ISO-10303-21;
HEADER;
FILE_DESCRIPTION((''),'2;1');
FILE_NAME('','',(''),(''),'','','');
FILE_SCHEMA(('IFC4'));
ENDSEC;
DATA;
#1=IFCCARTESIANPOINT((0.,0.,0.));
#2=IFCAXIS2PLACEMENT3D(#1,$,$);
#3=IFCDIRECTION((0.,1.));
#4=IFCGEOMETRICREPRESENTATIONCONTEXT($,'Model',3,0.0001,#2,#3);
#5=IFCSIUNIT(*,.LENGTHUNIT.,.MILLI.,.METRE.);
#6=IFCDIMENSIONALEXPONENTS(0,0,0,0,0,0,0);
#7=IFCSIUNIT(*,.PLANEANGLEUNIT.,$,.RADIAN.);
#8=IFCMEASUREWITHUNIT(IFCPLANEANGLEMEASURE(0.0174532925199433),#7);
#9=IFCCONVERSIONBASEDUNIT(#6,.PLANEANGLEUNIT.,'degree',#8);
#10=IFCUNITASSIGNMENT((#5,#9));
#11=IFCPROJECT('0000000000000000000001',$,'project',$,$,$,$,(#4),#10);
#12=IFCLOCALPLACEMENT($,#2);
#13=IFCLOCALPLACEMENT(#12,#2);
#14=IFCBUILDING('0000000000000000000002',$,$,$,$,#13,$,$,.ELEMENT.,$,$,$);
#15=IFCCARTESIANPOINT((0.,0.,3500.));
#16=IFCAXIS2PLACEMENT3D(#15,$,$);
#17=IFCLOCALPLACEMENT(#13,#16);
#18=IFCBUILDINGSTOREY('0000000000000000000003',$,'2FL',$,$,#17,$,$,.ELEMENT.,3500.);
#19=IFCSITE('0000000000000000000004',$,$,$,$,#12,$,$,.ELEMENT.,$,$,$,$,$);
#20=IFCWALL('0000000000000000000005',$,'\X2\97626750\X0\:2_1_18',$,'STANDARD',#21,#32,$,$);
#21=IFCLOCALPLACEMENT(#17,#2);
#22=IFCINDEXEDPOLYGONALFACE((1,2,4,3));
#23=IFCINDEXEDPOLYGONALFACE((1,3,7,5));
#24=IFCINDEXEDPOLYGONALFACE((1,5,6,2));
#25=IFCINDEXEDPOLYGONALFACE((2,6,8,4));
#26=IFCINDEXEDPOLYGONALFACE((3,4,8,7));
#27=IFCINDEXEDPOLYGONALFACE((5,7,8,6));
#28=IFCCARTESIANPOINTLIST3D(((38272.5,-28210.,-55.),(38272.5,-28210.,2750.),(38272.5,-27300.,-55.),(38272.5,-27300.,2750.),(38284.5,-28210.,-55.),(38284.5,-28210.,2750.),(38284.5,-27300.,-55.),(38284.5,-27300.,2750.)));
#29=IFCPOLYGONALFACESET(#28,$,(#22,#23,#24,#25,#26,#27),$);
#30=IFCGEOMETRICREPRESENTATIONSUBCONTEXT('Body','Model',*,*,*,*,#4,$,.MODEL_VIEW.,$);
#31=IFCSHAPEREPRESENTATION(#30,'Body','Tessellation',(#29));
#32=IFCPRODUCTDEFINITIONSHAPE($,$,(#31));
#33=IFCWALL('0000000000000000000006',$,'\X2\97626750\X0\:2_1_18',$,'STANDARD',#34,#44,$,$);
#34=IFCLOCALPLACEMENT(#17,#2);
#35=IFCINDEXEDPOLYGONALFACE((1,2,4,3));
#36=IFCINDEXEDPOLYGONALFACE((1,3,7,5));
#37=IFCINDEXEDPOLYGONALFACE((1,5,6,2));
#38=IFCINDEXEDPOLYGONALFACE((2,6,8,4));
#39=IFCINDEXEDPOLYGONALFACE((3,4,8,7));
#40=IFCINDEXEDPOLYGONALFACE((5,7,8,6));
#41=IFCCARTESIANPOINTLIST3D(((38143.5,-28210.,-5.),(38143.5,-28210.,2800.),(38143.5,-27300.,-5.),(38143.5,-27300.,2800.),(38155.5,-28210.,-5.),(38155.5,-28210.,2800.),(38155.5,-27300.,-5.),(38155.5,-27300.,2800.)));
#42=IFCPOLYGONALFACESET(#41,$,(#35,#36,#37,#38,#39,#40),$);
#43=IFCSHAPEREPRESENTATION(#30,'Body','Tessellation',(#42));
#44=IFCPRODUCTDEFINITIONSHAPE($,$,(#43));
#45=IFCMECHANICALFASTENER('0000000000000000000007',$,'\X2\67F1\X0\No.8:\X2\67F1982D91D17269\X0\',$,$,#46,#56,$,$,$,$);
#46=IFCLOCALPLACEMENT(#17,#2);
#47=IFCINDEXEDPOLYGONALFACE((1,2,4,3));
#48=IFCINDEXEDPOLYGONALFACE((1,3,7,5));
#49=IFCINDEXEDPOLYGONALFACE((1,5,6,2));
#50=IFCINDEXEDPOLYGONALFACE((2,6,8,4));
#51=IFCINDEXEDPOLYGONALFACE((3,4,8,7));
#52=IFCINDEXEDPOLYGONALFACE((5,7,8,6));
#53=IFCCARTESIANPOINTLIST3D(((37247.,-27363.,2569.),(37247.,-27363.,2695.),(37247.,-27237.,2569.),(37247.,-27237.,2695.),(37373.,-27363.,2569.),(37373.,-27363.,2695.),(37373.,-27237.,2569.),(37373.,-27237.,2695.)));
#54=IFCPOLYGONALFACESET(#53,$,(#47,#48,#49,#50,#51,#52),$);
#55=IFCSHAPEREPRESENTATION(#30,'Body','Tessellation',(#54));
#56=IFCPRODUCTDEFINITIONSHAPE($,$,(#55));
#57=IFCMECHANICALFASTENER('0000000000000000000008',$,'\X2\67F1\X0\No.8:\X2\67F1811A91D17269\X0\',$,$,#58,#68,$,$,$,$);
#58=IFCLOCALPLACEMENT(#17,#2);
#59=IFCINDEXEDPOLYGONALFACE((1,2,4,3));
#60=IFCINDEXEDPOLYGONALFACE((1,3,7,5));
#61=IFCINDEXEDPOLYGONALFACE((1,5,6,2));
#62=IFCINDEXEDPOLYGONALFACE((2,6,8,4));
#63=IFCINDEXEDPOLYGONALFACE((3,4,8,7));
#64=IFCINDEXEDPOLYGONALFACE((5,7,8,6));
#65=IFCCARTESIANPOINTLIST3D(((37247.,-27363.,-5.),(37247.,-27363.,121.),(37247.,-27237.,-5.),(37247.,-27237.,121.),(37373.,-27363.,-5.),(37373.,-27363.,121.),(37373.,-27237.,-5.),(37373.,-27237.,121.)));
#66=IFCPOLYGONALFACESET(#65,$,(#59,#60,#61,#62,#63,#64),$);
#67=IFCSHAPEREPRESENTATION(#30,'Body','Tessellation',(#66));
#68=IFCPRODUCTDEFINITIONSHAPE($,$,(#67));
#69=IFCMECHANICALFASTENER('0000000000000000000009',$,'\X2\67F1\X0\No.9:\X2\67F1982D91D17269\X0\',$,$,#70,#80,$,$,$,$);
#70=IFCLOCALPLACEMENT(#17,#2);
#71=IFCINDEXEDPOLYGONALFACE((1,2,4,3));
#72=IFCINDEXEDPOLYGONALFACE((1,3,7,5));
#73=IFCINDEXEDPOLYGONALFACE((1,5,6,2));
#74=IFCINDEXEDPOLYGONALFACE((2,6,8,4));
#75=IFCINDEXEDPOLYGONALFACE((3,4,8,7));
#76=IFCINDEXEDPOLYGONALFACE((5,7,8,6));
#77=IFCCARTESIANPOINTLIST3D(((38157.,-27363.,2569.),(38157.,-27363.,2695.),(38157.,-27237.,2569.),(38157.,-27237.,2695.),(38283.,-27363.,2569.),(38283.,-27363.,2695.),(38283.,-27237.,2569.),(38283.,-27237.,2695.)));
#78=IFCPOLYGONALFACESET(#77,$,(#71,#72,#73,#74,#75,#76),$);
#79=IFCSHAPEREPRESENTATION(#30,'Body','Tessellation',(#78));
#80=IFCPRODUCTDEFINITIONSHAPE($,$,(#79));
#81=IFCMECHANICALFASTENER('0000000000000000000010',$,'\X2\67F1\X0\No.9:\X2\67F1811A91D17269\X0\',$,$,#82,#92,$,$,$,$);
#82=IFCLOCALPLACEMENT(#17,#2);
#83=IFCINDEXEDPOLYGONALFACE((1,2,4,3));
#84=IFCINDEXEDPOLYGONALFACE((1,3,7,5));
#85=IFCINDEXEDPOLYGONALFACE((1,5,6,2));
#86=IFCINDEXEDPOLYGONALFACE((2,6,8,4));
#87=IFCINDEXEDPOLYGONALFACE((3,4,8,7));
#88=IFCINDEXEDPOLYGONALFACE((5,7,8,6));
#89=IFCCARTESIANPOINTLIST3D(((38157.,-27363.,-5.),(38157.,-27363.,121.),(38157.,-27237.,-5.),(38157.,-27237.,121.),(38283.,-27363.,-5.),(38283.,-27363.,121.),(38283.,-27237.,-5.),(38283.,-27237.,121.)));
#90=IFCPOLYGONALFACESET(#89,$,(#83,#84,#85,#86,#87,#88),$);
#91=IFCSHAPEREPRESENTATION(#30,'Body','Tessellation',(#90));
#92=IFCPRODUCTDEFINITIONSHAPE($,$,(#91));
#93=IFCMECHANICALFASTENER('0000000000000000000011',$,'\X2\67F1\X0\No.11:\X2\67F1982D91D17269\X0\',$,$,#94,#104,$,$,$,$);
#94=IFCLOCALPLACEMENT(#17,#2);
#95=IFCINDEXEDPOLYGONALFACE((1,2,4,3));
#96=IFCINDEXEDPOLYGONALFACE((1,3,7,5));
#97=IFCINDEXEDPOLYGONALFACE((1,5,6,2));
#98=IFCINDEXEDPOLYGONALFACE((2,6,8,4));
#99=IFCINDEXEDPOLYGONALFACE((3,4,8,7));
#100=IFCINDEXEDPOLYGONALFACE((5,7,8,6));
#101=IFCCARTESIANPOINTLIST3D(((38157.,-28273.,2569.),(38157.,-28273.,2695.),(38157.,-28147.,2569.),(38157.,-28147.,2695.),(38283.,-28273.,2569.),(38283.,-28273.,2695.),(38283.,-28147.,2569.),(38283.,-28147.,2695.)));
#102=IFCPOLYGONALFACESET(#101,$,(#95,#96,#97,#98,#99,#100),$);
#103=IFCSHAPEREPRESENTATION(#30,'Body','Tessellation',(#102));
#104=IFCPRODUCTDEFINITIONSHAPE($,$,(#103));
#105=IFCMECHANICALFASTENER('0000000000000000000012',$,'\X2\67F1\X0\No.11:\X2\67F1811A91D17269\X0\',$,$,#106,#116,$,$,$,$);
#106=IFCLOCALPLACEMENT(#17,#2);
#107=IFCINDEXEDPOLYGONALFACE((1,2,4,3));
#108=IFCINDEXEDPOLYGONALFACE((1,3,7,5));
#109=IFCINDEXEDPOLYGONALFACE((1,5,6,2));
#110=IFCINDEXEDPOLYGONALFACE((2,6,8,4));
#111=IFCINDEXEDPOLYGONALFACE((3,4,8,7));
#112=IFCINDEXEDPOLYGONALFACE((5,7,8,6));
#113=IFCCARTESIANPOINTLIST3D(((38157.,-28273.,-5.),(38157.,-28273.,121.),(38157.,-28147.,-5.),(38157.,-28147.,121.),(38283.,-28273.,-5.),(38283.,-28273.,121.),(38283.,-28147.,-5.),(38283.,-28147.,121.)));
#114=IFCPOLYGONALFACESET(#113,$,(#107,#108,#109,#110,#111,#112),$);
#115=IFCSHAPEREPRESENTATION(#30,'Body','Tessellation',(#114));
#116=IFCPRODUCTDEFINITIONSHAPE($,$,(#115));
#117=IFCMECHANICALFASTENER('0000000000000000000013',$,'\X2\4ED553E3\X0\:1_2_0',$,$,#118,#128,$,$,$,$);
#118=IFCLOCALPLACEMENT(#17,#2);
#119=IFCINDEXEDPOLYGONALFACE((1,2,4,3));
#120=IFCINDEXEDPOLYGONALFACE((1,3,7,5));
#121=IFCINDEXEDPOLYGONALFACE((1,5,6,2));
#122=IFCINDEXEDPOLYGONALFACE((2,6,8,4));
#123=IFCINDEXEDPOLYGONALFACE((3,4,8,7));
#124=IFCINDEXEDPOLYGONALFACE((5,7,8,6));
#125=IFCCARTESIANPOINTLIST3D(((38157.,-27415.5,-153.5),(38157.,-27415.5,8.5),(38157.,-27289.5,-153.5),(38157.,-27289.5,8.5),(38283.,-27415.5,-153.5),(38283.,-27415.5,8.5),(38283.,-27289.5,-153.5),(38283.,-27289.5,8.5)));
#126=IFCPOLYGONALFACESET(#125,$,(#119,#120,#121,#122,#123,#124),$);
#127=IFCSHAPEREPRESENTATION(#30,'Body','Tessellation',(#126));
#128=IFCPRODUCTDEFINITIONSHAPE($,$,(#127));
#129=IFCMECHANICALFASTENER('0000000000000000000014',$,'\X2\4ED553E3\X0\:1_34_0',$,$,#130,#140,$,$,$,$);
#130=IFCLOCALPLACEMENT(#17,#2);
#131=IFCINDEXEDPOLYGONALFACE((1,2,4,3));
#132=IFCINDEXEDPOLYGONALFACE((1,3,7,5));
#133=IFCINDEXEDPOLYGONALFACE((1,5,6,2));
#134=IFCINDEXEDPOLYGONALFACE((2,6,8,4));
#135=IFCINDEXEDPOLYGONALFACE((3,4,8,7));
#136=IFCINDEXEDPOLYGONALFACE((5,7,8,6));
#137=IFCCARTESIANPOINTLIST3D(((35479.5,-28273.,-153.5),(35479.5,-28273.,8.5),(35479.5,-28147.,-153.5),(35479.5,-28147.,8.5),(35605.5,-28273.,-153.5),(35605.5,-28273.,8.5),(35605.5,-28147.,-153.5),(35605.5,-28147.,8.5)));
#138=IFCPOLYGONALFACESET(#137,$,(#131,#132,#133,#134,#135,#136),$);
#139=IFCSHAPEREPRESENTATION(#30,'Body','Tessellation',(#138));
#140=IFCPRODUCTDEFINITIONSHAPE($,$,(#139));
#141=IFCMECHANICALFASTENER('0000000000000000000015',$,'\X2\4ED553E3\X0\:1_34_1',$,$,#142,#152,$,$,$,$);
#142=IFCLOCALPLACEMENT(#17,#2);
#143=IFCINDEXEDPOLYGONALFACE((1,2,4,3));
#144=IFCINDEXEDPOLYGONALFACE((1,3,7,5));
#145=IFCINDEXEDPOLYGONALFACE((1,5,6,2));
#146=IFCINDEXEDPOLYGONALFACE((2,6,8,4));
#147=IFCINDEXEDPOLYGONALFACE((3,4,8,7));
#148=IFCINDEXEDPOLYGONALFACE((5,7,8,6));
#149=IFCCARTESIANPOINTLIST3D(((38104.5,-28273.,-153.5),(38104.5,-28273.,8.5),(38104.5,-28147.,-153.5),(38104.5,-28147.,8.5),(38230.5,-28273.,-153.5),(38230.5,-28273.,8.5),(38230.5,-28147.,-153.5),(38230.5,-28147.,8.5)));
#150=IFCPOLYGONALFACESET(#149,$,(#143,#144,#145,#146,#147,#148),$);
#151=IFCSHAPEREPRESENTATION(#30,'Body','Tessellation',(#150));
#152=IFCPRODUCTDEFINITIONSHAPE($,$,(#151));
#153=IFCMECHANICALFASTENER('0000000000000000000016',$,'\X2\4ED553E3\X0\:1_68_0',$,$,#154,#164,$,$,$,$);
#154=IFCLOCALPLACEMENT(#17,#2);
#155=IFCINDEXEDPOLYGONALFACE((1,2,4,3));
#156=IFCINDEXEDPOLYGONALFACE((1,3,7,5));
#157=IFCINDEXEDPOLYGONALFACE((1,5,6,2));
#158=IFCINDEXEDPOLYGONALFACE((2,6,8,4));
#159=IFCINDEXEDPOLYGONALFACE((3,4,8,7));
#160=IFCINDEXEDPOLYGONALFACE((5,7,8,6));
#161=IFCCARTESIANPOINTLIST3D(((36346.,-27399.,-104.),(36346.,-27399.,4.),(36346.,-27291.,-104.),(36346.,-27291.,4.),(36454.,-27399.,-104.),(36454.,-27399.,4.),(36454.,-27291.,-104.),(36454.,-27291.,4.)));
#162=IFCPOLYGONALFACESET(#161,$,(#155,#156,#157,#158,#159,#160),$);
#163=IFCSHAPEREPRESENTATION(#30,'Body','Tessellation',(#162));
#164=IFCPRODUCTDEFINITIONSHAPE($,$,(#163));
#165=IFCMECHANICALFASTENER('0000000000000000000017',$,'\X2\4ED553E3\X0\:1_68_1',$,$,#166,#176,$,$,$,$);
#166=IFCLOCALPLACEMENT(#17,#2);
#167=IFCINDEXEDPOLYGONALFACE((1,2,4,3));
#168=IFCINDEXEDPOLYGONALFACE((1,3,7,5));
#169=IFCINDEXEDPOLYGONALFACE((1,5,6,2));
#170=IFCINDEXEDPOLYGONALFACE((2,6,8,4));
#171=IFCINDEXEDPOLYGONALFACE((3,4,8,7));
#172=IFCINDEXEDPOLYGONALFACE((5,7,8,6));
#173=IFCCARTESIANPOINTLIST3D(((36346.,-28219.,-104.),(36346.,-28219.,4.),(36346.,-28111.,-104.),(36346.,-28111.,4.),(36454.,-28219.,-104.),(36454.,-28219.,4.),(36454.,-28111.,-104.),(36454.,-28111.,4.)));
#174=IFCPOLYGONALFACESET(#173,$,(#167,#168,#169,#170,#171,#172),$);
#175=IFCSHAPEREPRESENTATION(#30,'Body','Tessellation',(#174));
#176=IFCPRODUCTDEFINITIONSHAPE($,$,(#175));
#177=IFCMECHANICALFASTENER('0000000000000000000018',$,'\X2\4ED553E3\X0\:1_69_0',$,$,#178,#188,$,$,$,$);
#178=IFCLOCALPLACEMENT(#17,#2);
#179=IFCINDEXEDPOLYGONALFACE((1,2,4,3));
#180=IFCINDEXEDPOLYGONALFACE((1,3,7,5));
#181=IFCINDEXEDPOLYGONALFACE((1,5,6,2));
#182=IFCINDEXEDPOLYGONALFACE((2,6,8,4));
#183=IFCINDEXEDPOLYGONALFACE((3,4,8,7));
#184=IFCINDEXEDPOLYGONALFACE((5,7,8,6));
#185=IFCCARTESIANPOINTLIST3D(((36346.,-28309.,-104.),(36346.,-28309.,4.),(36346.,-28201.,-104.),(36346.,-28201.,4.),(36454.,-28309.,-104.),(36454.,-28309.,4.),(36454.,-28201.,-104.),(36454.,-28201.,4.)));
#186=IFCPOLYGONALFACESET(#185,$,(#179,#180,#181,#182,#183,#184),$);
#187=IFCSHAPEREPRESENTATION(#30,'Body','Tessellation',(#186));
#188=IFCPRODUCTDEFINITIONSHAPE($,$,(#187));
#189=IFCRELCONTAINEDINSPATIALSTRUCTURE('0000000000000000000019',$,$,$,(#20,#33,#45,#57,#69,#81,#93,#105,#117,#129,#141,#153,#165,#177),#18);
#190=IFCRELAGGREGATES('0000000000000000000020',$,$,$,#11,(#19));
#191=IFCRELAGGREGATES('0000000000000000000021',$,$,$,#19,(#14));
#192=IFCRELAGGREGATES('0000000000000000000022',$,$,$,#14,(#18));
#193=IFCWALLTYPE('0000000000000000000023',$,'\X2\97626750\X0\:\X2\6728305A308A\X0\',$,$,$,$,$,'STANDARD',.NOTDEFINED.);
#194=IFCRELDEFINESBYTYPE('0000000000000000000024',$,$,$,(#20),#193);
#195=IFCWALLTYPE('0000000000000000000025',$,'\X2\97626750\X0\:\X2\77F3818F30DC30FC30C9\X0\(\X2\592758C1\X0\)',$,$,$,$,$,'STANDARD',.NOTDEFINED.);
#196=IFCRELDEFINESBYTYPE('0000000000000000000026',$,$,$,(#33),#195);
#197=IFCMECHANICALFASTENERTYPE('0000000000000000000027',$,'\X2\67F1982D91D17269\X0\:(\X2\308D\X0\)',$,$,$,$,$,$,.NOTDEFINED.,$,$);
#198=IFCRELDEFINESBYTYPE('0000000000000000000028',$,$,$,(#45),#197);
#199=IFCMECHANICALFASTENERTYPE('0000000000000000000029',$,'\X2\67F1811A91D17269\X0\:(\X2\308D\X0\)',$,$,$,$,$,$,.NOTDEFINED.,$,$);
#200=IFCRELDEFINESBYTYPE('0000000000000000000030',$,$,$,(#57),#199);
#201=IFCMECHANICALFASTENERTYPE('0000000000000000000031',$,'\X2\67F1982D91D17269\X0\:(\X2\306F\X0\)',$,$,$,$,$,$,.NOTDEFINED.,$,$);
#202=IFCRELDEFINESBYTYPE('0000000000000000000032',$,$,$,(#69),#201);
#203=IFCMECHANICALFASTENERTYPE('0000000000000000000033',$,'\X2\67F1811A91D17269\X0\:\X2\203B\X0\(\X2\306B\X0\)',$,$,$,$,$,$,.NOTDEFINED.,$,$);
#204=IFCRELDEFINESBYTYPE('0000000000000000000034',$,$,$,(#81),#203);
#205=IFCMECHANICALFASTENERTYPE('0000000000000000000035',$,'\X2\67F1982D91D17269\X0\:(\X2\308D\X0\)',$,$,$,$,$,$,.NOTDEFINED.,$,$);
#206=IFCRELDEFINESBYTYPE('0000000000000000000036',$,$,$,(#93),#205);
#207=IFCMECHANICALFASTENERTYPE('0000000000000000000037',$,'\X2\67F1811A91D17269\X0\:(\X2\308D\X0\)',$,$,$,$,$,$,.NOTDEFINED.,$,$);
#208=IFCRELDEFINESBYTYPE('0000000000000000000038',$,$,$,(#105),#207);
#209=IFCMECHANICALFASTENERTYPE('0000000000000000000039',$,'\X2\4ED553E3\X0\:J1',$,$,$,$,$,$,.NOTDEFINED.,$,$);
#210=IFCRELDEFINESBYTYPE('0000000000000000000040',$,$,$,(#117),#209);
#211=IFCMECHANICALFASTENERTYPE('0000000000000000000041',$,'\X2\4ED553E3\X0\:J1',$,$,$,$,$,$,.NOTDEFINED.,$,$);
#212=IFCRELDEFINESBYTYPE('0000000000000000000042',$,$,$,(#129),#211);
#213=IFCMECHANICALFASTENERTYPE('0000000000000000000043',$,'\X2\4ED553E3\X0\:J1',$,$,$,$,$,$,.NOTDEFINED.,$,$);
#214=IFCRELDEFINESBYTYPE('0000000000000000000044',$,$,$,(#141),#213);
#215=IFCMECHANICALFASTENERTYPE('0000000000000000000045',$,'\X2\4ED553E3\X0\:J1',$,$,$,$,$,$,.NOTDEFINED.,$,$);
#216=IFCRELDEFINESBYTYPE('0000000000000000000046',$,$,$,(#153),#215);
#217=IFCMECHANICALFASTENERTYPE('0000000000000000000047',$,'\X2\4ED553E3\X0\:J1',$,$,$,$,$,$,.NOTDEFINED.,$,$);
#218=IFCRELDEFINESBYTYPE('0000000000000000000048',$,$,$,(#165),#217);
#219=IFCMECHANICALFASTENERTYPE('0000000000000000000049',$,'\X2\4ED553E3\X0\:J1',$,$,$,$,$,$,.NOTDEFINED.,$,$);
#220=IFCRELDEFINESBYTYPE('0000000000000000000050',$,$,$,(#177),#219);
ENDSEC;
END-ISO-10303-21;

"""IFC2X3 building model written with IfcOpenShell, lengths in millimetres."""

from ifc_helpers import new_model, entity, si_unit, converted_unit, direction, frame, origin, origin_with_axes, origin_2d, place, context, subcontext, project, spatial, polyline, rectangle, outline, extrude, type_object, element, save


model = new_model("IFC2X3")

# Units and contexts
model_context = context("Model", 3, precision=0.0001, world=origin(), true_north=direction((0.0, 1.0)))
body_context = subcontext(model_context, "Body", "Model", "MODEL_VIEW")
ifc_project = project(units=[si_unit("LENGTHUNIT", "METRE", prefix="MILLI"), converted_unit("PLANEANGLEUNIT", "degree", entity("IfcPlaneAngleMeasure", 0.0174532925199433), si_unit("PLANEANGLEUNIT", "RADIAN"), dimensions=[0, 0, 0, 0, 0, 0, 0])], contexts=[model_context])

# Site, building, storey
site_placement = place(None, origin())
site = spatial("IfcSite", under=ifc_project, at=site_placement, CompositionType="ELEMENT")
building_placement = place(site_placement, origin())
building = spatial("IfcBuilding", under=site, at=building_placement, CompositionType="ELEMENT")
storey_placement = place(building_placement, frame((0.0, 0.0, 3500.0)))
storey = spatial("IfcBuildingStorey", under=building, at=storey_placement, Name="2FL", CompositionType="ELEMENT", Elevation=3500.0)

# Walls
wall_type_1 = type_object("IfcWallType", Name="面材:木ずり", ElementType="STANDARD", PredefinedType="NOTDEFINED")
wall_1_placement = place(storey_placement, frame((38284.5, -27755.0, -55.0), z_axis=(-1.0, 0.0, 0.0), x_axis=(0.0, -1.0, 0.0)))
element("IfcWall", 1, at=wall_1_placement, inside=storey, type_object=wall_type_1, Name="面材:2_1_18", ObjectType="STANDARD", context=body_context, shape_type="SweptSolid", body=[
    extrude(outline(polyline([(455.0, 0.0, 0.0), (-455.0, 0.0, 0.0), (-455.0, 2805.0, 0.0), (455.0, 2805.0, 0.0), (455.0, 0.0, 0.0)])), origin_with_axes(), (0.0, 0.0, 1.0), 12.0),
])
wall_type_2 = type_object("IfcWallType", Name="面材:石膏ボード(大壁)", ElementType="STANDARD", PredefinedType="NOTDEFINED")
wall_2_placement = place(storey_placement, frame((38155.5, -27755.0, -5.0), z_axis=(-1.0, 0.0, 0.0), x_axis=(0.0, -1.0, 0.0)))
element("IfcWall", 2, at=wall_2_placement, inside=storey, type_object=wall_type_2, Name="面材:2_1_18", ObjectType="STANDARD", context=body_context, shape_type="SweptSolid", body=[
    extrude(outline(polyline([(455.0, 0.0, 0.0), (-455.0, 0.0, 0.0), (-455.0, 2805.0, 0.0), (455.0, 2805.0, 0.0), (455.0, 0.0, 0.0)])), origin_with_axes(), (0.0, 0.0, 1.0), 12.0),
])

# Mechanical fasteners
mechanical_fastener_type_1 = type_object("IfcMechanicalFastenerType", Name="柱頭金物:(ろ)")
mechanical_fastener_1_placement = place(storey_placement, frame((37310.0, -27300.0, 2569.0)))
element("IfcMechanicalFastener", 3, at=mechanical_fastener_1_placement, inside=storey, type_object=mechanical_fastener_type_1, Name="柱No.8:柱頭金物", context=body_context, shape_type="SweptSolid", body=[
    extrude(rectangle(XDim=126.0, YDim=126.0, at=origin_2d()), origin_with_axes(), (0.0, 0.0, 1.0), 126.0),
])
mechanical_fastener_type_2 = type_object("IfcMechanicalFastenerType", Name="柱脚金物:(ろ)")
mechanical_fastener_2_placement = place(storey_placement, frame((37310.0, -27300.0, -5.0)))
element("IfcMechanicalFastener", 4, at=mechanical_fastener_2_placement, inside=storey, type_object=mechanical_fastener_type_2, Name="柱No.8:柱脚金物", context=body_context, shape_type="SweptSolid", body=[
    extrude(rectangle(XDim=126.0, YDim=126.0, at=origin_2d()), origin_with_axes(), (0.0, 0.0, 1.0), 126.0),
])
mechanical_fastener_type_3 = type_object("IfcMechanicalFastenerType", Name="柱頭金物:(は)")
mechanical_fastener_3_placement = place(storey_placement, frame((38220.0, -27300.0, 2569.0)))
element("IfcMechanicalFastener", 5, at=mechanical_fastener_3_placement, inside=storey, type_object=mechanical_fastener_type_3, Name="柱No.9:柱頭金物", context=body_context, shape_type="SweptSolid", body=[
    extrude(rectangle(XDim=126.0, YDim=126.0, at=origin_2d()), origin_with_axes(), (0.0, 0.0, 1.0), 126.0),
])
mechanical_fastener_type_4 = type_object("IfcMechanicalFastenerType", Name="柱脚金物:※(に)")
mechanical_fastener_4_placement = place(storey_placement, frame((38220.0, -27300.0, -5.0)))
element("IfcMechanicalFastener", 6, at=mechanical_fastener_4_placement, inside=storey, type_object=mechanical_fastener_type_4, Name="柱No.9:柱脚金物", context=body_context, shape_type="SweptSolid", body=[
    extrude(rectangle(XDim=126.0, YDim=126.0, at=origin_2d()), origin_with_axes(), (0.0, 0.0, 1.0), 126.0),
])
mechanical_fastener_type_5 = type_object("IfcMechanicalFastenerType", Name="柱頭金物:(ろ)")
mechanical_fastener_5_placement = place(storey_placement, frame((38220.0, -28210.0, 2569.0)))
element("IfcMechanicalFastener", 7, at=mechanical_fastener_5_placement, inside=storey, type_object=mechanical_fastener_type_5, Name="柱No.11:柱頭金物", context=body_context, shape_type="SweptSolid", body=[
    extrude(rectangle(XDim=126.0, YDim=126.0, at=origin_2d()), origin_with_axes(), (0.0, 0.0, 1.0), 126.0),
])
mechanical_fastener_type_6 = type_object("IfcMechanicalFastenerType", Name="柱脚金物:(ろ)")
mechanical_fastener_6_placement = place(storey_placement, frame((38220.0, -28210.0, -5.0)))
element("IfcMechanicalFastener", 8, at=mechanical_fastener_6_placement, inside=storey, type_object=mechanical_fastener_type_6, Name="柱No.11:柱脚金物", context=body_context, shape_type="SweptSolid", body=[
    extrude(rectangle(XDim=126.0, YDim=126.0, at=origin_2d()), origin_with_axes(), (0.0, 0.0, 1.0), 126.0),
])
mechanical_fastener_type_7 = type_object("IfcMechanicalFastenerType", Name="仕口:J1")
mechanical_fastener_7_placement = place(storey_placement, frame((38220.0, -27352.5, -153.5)))
element("IfcMechanicalFastener", 9, at=mechanical_fastener_7_placement, inside=storey, type_object=mechanical_fastener_type_7, Name="仕口:1_2_0", context=body_context, shape_type="SweptSolid", body=[
    extrude(rectangle(XDim=126.0, YDim=126.0, at=origin_2d()), origin_with_axes(), (0.0, 0.0, 1.0), 162.0),
])
mechanical_fastener_type_8 = type_object("IfcMechanicalFastenerType", Name="仕口:J1")
mechanical_fastener_8_placement = place(storey_placement, frame((35542.5, -28210.0, -153.5)))
element("IfcMechanicalFastener", 10, at=mechanical_fastener_8_placement, inside=storey, type_object=mechanical_fastener_type_8, Name="仕口:1_34_0", context=body_context, shape_type="SweptSolid", body=[
    extrude(rectangle(XDim=126.0, YDim=126.0, at=origin_2d()), origin_with_axes(), (0.0, 0.0, 1.0), 162.0),
])
mechanical_fastener_type_9 = type_object("IfcMechanicalFastenerType", Name="仕口:J1")
mechanical_fastener_9_placement = place(storey_placement, frame((38167.5, -28210.0, -153.5)))
element("IfcMechanicalFastener", 11, at=mechanical_fastener_9_placement, inside=storey, type_object=mechanical_fastener_type_9, Name="仕口:1_34_1", context=body_context, shape_type="SweptSolid", body=[
    extrude(rectangle(XDim=126.0, YDim=126.0, at=origin_2d()), origin_with_axes(), (0.0, 0.0, 1.0), 162.0),
])
mechanical_fastener_type_10 = type_object("IfcMechanicalFastenerType", Name="仕口:J1")
mechanical_fastener_10_placement = place(storey_placement, frame((36400.0, -27345.0, -104.0)))
element("IfcMechanicalFastener", 12, at=mechanical_fastener_10_placement, inside=storey, type_object=mechanical_fastener_type_10, Name="仕口:1_68_0", context=body_context, shape_type="SweptSolid", body=[
    extrude(rectangle(XDim=108.0, YDim=108.0, at=origin_2d()), origin_with_axes(), (0.0, 0.0, 1.0), 108.0),
])
mechanical_fastener_type_11 = type_object("IfcMechanicalFastenerType", Name="仕口:J1")
mechanical_fastener_11_placement = place(storey_placement, frame((36400.0, -28165.0, -104.0)))
element("IfcMechanicalFastener", 13, at=mechanical_fastener_11_placement, inside=storey, type_object=mechanical_fastener_type_11, Name="仕口:1_68_1", context=body_context, shape_type="SweptSolid", body=[
    extrude(rectangle(XDim=108.0, YDim=108.0, at=origin_2d()), origin_with_axes(), (0.0, 0.0, 1.0), 108.0),
])
mechanical_fastener_type_12 = type_object("IfcMechanicalFastenerType", Name="仕口:J1")
mechanical_fastener_12_placement = place(storey_placement, frame((36400.0, -28255.0, -104.0)))
element("IfcMechanicalFastener", 14, at=mechanical_fastener_12_placement, inside=storey, type_object=mechanical_fastener_type_12, Name="仕口:1_69_0", context=body_context, shape_type="SweptSolid", body=[
    extrude(rectangle(XDim=108.0, YDim=108.0, at=origin_2d()), origin_with_axes(), (0.0, 0.0, 1.0), 108.0),
])

save(model, "model.ifc")
